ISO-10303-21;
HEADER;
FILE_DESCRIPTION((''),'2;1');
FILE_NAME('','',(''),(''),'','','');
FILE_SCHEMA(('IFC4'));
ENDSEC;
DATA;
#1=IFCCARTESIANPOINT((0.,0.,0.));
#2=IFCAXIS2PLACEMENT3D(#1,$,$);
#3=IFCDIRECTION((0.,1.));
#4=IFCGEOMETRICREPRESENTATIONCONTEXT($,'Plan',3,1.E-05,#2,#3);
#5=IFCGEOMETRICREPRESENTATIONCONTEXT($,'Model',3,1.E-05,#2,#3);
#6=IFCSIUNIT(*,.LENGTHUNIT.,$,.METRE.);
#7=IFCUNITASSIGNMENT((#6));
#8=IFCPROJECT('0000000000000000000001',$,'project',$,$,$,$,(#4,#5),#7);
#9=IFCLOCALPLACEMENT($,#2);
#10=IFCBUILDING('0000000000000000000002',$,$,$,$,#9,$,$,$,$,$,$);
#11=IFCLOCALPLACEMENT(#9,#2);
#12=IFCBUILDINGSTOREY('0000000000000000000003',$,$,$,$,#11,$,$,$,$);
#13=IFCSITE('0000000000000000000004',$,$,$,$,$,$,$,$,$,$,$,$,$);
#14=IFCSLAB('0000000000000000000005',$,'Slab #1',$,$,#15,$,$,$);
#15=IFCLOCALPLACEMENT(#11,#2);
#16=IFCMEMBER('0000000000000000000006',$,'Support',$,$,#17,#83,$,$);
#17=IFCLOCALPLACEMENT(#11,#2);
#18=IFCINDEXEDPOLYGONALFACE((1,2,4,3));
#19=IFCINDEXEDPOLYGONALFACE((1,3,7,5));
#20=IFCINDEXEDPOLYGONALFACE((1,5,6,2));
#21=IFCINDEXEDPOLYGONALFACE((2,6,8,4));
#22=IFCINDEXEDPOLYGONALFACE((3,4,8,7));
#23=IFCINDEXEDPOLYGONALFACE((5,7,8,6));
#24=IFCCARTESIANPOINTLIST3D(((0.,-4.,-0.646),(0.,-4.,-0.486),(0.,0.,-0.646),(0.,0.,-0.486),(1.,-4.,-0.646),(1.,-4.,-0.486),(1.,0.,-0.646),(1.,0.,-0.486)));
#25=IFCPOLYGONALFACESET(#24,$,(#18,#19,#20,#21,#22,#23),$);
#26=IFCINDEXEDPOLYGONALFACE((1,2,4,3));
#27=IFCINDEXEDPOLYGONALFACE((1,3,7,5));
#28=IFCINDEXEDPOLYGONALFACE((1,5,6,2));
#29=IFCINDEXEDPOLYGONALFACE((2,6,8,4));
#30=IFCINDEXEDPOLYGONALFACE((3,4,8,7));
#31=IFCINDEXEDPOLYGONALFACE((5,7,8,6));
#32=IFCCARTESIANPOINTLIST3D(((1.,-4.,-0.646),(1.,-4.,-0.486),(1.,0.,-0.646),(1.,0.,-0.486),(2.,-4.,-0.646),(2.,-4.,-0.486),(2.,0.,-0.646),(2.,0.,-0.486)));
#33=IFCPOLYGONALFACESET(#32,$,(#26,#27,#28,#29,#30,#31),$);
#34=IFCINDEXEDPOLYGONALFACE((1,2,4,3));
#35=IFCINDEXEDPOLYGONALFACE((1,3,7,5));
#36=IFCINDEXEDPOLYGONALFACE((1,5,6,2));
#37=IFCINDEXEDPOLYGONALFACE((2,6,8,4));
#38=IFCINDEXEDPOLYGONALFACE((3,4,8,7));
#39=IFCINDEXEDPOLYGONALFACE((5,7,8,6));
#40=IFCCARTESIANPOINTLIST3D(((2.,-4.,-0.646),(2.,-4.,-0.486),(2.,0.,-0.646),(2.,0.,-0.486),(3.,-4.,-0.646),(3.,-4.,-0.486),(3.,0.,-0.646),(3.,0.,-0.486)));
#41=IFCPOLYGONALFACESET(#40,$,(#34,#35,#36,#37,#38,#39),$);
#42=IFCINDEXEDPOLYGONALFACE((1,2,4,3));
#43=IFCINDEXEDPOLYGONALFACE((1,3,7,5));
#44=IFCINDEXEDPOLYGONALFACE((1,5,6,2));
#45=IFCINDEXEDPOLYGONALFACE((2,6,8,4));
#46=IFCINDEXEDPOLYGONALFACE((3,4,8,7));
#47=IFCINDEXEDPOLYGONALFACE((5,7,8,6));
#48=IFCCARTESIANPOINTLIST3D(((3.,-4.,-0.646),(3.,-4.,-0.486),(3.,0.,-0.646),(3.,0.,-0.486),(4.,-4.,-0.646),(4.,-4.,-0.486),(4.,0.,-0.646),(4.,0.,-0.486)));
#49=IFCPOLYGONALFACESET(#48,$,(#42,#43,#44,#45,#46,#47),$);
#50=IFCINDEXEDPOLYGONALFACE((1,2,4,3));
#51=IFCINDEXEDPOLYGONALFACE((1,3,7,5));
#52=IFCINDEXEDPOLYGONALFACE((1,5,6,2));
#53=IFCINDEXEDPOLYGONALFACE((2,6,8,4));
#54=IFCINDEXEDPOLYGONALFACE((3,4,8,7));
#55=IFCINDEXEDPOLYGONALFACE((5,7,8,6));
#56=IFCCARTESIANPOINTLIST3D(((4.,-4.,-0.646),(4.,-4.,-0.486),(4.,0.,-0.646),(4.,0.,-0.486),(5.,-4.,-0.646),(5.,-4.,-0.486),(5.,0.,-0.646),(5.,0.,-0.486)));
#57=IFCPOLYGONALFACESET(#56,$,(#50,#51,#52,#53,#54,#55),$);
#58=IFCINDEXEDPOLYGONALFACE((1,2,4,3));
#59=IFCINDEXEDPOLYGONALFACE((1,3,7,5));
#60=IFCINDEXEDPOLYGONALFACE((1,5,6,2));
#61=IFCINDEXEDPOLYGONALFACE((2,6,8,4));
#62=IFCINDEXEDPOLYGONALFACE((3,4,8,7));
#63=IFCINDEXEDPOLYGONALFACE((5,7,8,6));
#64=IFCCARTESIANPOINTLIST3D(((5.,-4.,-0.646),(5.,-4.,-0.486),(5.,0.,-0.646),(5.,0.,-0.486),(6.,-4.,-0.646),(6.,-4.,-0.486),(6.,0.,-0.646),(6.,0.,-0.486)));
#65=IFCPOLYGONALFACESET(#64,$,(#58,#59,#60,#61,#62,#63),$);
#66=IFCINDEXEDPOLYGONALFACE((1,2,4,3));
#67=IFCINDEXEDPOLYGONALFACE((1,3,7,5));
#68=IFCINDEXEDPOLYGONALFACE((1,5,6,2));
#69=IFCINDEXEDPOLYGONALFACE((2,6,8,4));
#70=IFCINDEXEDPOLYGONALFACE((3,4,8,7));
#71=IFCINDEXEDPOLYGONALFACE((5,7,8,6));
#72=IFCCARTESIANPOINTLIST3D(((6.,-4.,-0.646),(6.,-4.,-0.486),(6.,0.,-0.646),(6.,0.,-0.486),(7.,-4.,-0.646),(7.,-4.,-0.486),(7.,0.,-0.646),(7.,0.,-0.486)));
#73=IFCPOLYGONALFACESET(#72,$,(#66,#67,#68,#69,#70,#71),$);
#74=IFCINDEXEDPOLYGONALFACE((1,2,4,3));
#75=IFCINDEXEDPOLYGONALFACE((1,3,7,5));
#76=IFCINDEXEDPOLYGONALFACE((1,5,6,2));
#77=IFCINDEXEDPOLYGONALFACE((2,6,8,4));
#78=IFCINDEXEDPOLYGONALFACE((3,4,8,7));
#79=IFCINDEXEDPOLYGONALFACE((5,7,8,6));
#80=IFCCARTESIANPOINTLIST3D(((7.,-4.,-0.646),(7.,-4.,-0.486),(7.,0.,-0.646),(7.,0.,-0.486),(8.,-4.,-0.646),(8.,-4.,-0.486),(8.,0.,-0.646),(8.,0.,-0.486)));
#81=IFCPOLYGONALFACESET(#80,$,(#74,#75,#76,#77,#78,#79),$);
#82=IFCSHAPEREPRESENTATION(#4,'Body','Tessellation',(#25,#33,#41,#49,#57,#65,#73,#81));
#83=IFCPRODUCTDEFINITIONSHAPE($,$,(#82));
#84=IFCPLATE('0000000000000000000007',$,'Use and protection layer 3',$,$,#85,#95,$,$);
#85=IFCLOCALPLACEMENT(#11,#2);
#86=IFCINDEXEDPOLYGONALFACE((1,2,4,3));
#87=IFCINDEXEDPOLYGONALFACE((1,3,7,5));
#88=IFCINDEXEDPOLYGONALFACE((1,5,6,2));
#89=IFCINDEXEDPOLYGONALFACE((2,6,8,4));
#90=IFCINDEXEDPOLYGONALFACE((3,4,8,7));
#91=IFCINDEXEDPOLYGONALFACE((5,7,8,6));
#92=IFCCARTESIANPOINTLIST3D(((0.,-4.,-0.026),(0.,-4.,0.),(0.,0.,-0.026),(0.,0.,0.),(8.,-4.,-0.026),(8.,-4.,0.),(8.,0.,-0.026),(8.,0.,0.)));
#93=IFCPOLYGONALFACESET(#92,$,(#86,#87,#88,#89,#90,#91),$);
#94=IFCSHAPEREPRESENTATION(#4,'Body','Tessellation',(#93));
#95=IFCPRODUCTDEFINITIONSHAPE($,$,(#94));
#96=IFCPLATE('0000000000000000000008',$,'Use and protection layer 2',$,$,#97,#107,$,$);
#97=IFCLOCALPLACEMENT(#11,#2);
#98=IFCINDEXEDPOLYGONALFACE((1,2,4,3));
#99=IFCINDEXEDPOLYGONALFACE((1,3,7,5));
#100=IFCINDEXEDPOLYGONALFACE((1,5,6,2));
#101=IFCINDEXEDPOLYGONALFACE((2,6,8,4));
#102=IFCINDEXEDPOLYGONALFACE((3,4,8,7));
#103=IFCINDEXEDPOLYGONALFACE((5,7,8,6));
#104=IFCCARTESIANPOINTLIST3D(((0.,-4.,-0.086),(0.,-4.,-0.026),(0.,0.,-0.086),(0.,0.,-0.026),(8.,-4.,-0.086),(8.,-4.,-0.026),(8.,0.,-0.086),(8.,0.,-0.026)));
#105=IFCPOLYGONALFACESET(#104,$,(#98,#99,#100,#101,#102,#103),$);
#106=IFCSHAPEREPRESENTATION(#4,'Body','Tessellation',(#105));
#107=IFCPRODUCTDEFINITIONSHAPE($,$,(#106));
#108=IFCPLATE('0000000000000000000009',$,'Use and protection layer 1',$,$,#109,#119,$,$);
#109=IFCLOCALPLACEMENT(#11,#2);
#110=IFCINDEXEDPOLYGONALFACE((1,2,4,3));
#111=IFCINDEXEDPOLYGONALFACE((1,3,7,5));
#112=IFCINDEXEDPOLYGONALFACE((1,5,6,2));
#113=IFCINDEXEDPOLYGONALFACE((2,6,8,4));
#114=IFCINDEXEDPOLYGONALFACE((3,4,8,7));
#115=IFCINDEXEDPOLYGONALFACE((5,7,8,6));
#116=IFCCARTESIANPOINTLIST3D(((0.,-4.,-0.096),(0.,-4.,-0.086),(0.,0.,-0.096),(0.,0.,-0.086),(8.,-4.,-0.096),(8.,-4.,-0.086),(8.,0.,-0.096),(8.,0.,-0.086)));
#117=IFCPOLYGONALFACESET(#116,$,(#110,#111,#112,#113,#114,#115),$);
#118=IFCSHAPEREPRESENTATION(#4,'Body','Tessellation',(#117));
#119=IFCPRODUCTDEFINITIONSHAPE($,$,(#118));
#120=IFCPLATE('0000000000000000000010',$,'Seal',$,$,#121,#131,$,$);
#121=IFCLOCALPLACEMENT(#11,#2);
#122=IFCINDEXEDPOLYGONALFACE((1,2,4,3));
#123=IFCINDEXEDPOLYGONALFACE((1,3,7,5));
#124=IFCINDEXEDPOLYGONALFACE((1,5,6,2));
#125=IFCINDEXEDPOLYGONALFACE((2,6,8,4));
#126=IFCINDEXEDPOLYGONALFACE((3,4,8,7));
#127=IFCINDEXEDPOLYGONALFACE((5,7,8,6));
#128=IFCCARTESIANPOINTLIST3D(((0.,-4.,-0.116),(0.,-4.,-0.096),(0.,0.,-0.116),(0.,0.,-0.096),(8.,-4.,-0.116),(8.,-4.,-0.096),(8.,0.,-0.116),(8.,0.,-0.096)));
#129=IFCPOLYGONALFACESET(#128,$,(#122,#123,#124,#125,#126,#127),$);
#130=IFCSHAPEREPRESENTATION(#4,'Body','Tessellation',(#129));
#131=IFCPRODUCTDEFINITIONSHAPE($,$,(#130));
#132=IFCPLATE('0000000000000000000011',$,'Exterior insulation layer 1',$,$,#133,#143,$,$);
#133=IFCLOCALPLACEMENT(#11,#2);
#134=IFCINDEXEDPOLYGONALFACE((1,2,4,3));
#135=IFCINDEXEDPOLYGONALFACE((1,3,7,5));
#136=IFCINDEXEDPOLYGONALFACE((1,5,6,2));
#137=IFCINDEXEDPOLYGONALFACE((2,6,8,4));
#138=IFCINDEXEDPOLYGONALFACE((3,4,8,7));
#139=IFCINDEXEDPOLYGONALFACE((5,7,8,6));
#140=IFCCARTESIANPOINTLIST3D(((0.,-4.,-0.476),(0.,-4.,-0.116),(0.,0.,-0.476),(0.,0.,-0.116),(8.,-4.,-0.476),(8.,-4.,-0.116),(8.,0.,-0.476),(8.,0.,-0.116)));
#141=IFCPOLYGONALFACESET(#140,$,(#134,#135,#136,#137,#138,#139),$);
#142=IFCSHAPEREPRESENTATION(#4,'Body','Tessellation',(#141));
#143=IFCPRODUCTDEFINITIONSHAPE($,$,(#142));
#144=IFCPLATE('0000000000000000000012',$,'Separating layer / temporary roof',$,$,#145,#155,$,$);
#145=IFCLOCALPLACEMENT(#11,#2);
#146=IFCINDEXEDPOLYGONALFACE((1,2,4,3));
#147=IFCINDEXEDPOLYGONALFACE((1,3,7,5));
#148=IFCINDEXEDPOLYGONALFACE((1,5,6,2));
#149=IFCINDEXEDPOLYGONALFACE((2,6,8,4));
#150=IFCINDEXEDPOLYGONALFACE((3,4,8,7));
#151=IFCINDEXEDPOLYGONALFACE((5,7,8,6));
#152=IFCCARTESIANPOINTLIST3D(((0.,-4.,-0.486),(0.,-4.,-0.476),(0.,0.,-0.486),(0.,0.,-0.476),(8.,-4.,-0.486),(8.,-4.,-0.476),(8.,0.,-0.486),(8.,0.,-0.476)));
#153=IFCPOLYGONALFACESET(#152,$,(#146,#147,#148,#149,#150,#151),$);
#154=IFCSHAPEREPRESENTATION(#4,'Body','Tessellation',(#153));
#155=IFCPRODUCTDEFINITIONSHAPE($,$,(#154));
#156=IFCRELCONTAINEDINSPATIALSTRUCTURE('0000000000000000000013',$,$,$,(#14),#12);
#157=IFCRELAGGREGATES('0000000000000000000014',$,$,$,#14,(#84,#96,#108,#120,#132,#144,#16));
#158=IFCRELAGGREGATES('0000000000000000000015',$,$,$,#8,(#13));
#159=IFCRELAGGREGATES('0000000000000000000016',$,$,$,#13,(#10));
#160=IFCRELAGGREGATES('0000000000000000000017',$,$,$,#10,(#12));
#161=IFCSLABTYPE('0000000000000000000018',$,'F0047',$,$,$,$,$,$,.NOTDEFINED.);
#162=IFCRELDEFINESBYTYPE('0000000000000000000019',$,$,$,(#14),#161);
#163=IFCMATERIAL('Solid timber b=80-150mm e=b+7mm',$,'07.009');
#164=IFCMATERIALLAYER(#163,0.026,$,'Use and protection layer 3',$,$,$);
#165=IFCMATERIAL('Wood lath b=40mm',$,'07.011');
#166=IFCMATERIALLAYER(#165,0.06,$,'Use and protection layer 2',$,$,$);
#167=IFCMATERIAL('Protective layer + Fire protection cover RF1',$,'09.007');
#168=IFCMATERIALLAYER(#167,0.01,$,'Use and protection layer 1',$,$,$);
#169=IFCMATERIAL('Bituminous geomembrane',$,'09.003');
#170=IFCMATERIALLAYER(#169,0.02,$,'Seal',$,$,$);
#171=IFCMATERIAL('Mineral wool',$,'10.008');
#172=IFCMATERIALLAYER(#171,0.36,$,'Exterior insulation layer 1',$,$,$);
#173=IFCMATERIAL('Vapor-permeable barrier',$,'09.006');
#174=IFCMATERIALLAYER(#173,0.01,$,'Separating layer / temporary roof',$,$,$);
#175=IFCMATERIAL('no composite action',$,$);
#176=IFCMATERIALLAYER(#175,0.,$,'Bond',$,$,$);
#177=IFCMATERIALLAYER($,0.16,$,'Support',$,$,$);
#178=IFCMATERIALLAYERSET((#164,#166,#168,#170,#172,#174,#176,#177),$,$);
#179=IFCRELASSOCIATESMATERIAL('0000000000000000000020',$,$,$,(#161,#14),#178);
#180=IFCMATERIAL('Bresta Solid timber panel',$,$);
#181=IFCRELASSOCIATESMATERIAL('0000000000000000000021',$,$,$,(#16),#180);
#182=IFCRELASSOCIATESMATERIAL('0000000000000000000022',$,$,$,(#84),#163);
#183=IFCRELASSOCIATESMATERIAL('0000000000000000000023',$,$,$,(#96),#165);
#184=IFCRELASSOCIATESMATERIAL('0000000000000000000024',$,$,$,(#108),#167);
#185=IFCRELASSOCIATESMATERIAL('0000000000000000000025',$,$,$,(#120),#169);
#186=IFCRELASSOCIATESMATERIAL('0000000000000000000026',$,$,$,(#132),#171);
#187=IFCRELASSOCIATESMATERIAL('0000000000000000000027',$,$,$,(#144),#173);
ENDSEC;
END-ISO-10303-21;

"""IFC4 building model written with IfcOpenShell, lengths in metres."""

from ifc_helpers import new_model, si_unit, direction, frame, frame_2d, origin, origin_with_axes, place, context, project, spatial, rectangle, extrude, material, layer, layer_set, type_object, element, aggregate, save


model = new_model("IFC4")

# Units and contexts
plan_context = context("Plan", 3, precision=1e-05, world=origin(), true_north=direction((0.0, 1.0)))
model_context = context("Model", 3, precision=1e-05, world=origin(), true_north=direction((0.0, 1.0)))
ifc_project = project(units=[si_unit("LENGTHUNIT", "METRE")], contexts=[plan_context, model_context])

# Site, building, storey
site = spatial("IfcSite", under=ifc_project)
building_placement = place(None, origin())
building = spatial("IfcBuilding", under=site, at=building_placement)
storey_placement = place(building_placement, origin())
storey = spatial("IfcBuildingStorey", under=building, at=storey_placement)

# Slab, member, plates
ifc_material_1 = material(Name="Solid timber b=80-150mm e=b+7mm", Category="07.009")
ifc_layer_1 = layer(ifc_material_1, 0.026, Name="Use and protection layer 3")
ifc_material_2 = material(Name="Wood lath b=40mm", Category="07.011")
ifc_layer_2 = layer(ifc_material_2, 0.06, Name="Use and protection layer 2")
ifc_material_3 = material(Name="Protective layer + Fire protection cover RF1", Category="09.007")
ifc_layer_3 = layer(ifc_material_3, 0.01, Name="Use and protection layer 1")
ifc_material_4 = material(Name="Bituminous geomembrane", Category="09.003")
ifc_layer_4 = layer(ifc_material_4, 0.02, Name="Seal")
ifc_material_5 = material(Name="Mineral wool", Category="10.008")
ifc_layer_5 = layer(ifc_material_5, 0.36, Name="Exterior insulation layer 1")
ifc_material_6 = material(Name="Vapor-permeable barrier", Category="09.006")
ifc_layer_6 = layer(ifc_material_6, 0.01, Name="Separating layer / temporary roof")
ifc_material_7 = material(Name="no composite action")
ifc_layer_7 = layer(ifc_material_7, 0.0, Name="Bond")
ifc_layer_8 = layer(None, 0.16, Name="Support")
ifc_layer_set = layer_set([ifc_layer_1, ifc_layer_2, ifc_layer_3, ifc_layer_4, ifc_layer_5, ifc_layer_6, ifc_layer_7, ifc_layer_8])
slab_type = type_object("IfcSlabType", Name="F0047", PredefinedType="NOTDEFINED", material=ifc_layer_set)
slab_placement = place(None, frame((0.0, 0.0, 0.0), z_axis=(0.0, 0.0, -1.0), x_axis=(1.0, 0.0, 0.0)))
slab = element("IfcSlab", 1, at=slab_placement, inside=storey, type_object=slab_type, material=ifc_layer_set, Name="Slab #1")
ifc_material_8 = material(Name="Bresta Solid timber panel")
member_placement = place(slab_placement, origin())
member = element("IfcMember", 2, at=member_placement, material=ifc_material_8, Name="Support", context=plan_context, shape_type="SweptSolid", body=[
    extrude(rectangle(XDim=1.0, YDim=0.16, at=frame_2d((0.5, 0.08), x_axis=(1.0, 0.0))), frame((0.0, 4.0, 0.486), z_axis=(0.0, -1.0, 0.0), x_axis=(1.0, 0.0, 0.0)), (0.0, 0.0, 1.0), 4.0),
    extrude(rectangle(XDim=1.0, YDim=0.16, at=frame_2d((0.5, 0.08), x_axis=(1.0, 0.0))), frame((1.0, 4.0, 0.486), z_axis=(0.0, -1.0, 0.0), x_axis=(1.0, 0.0, 0.0)), (0.0, 0.0, 1.0), 4.0),
    extrude(rectangle(XDim=1.0, YDim=0.16, at=frame_2d((0.5, 0.08), x_axis=(1.0, 0.0))), frame((2.0, 4.0, 0.486), z_axis=(0.0, -1.0, 0.0), x_axis=(1.0, 0.0, 0.0)), (0.0, 0.0, 1.0), 4.0),
    extrude(rectangle(XDim=1.0, YDim=0.16, at=frame_2d((0.5, 0.08), x_axis=(1.0, 0.0))), frame((3.0, 4.0, 0.486), z_axis=(0.0, -1.0, 0.0), x_axis=(1.0, 0.0, 0.0)), (0.0, 0.0, 1.0), 4.0),
    extrude(rectangle(XDim=1.0, YDim=0.16, at=frame_2d((0.5, 0.08), x_axis=(1.0, 0.0))), frame((4.0, 4.0, 0.486), z_axis=(0.0, -1.0, 0.0), x_axis=(1.0, 0.0, 0.0)), (0.0, 0.0, 1.0), 4.0),
    extrude(rectangle(XDim=1.0, YDim=0.16, at=frame_2d((0.5, 0.08), x_axis=(1.0, 0.0))), frame((5.0, 4.0, 0.486), z_axis=(0.0, -1.0, 0.0), x_axis=(1.0, 0.0, 0.0)), (0.0, 0.0, 1.0), 4.0),
    extrude(rectangle(XDim=1.0, YDim=0.16, at=frame_2d((0.5, 0.08), x_axis=(1.0, 0.0))), frame((6.0, 4.0, 0.486), z_axis=(0.0, -1.0, 0.0), x_axis=(1.0, 0.0, 0.0)), (0.0, 0.0, 1.0), 4.0),
    extrude(rectangle(XDim=1.0, YDim=0.16, at=frame_2d((0.5, 0.08), x_axis=(1.0, 0.0))), frame((7.0, 4.0, 0.486), z_axis=(0.0, -1.0, 0.0), x_axis=(1.0, 0.0, 0.0)), (0.0, 0.0, 1.0), 4.0),
])
plate_1_placement = place(slab_placement, origin())
plate_1 = element("IfcPlate", 3, at=plate_1_placement, material=ifc_material_1, Name="Use and protection layer 3", context=plan_context, shape_type="SweptSolid", body=[
    extrude(rectangle(XDim=8.0, YDim=4.0, at=frame_2d((4.0, 2.0), x_axis=(1.0, 0.0))), origin_with_axes(), (0.0, 0.0, 1.0), 0.026),
])
plate_2_placement = place(slab_placement, origin())
plate_2 = element("IfcPlate", 4, at=plate_2_placement, material=ifc_material_2, Name="Use and protection layer 2", context=plan_context, shape_type="SweptSolid", body=[
    extrude(rectangle(XDim=8.0, YDim=4.0, at=frame_2d((4.0, 2.0), x_axis=(1.0, 0.0))), frame((0.0, 0.0, 0.026), z_axis=(0.0, 0.0, 1.0), x_axis=(1.0, 0.0, 0.0)), (0.0, 0.0, 1.0), 0.06),
])
plate_3_placement = place(slab_placement, origin())
plate_3 = element("IfcPlate", 5, at=plate_3_placement, material=ifc_material_3, Name="Use and protection layer 1", context=plan_context, shape_type="SweptSolid", body=[
    extrude(rectangle(XDim=8.0, YDim=4.0, at=frame_2d((4.0, 2.0), x_axis=(1.0, 0.0))), frame((0.0, 0.0, 0.086), z_axis=(0.0, 0.0, 1.0), x_axis=(1.0, 0.0, 0.0)), (0.0, 0.0, 1.0), 0.01),
])
plate_4_placement = place(slab_placement, origin())
plate_4 = element("IfcPlate", 6, at=plate_4_placement, material=ifc_material_4, Name="Seal", context=plan_context, shape_type="SweptSolid", body=[
    extrude(rectangle(XDim=8.0, YDim=4.0, at=frame_2d((4.0, 2.0), x_axis=(1.0, 0.0))), frame((0.0, 0.0, 0.096), z_axis=(0.0, 0.0, 1.0), x_axis=(1.0, 0.0, 0.0)), (0.0, 0.0, 1.0), 0.02),
])
plate_5_placement = place(slab_placement, origin())
plate_5 = element("IfcPlate", 7, at=plate_5_placement, material=ifc_material_5, Name="Exterior insulation layer 1", context=plan_context, shape_type="SweptSolid", body=[
    extrude(rectangle(XDim=8.0, YDim=4.0, at=frame_2d((4.0, 2.0), x_axis=(1.0, 0.0))), frame((0.0, 0.0, 0.116), z_axis=(0.0, 0.0, 1.0), x_axis=(1.0, 0.0, 0.0)), (0.0, 0.0, 1.0), 0.36),
])
plate_6_placement = place(slab_placement, origin())
plate_6 = element("IfcPlate", 8, at=plate_6_placement, material=ifc_material_6, Name="Separating layer / temporary roof", context=plan_context, shape_type="SweptSolid", body=[
    extrude(rectangle(XDim=8.0, YDim=4.0, at=frame_2d((4.0, 2.0), x_axis=(1.0, 0.0))), frame((0.0, 0.0, 0.476), z_axis=(0.0, 0.0, 1.0), x_axis=(1.0, 0.0, 0.0)), (0.0, 0.0, 1.0), 0.01),
])
aggregate(slab, [plate_1, plate_2, plate_3, plate_4, plate_5, plate_6, member])

save(model, "model.ifc")
